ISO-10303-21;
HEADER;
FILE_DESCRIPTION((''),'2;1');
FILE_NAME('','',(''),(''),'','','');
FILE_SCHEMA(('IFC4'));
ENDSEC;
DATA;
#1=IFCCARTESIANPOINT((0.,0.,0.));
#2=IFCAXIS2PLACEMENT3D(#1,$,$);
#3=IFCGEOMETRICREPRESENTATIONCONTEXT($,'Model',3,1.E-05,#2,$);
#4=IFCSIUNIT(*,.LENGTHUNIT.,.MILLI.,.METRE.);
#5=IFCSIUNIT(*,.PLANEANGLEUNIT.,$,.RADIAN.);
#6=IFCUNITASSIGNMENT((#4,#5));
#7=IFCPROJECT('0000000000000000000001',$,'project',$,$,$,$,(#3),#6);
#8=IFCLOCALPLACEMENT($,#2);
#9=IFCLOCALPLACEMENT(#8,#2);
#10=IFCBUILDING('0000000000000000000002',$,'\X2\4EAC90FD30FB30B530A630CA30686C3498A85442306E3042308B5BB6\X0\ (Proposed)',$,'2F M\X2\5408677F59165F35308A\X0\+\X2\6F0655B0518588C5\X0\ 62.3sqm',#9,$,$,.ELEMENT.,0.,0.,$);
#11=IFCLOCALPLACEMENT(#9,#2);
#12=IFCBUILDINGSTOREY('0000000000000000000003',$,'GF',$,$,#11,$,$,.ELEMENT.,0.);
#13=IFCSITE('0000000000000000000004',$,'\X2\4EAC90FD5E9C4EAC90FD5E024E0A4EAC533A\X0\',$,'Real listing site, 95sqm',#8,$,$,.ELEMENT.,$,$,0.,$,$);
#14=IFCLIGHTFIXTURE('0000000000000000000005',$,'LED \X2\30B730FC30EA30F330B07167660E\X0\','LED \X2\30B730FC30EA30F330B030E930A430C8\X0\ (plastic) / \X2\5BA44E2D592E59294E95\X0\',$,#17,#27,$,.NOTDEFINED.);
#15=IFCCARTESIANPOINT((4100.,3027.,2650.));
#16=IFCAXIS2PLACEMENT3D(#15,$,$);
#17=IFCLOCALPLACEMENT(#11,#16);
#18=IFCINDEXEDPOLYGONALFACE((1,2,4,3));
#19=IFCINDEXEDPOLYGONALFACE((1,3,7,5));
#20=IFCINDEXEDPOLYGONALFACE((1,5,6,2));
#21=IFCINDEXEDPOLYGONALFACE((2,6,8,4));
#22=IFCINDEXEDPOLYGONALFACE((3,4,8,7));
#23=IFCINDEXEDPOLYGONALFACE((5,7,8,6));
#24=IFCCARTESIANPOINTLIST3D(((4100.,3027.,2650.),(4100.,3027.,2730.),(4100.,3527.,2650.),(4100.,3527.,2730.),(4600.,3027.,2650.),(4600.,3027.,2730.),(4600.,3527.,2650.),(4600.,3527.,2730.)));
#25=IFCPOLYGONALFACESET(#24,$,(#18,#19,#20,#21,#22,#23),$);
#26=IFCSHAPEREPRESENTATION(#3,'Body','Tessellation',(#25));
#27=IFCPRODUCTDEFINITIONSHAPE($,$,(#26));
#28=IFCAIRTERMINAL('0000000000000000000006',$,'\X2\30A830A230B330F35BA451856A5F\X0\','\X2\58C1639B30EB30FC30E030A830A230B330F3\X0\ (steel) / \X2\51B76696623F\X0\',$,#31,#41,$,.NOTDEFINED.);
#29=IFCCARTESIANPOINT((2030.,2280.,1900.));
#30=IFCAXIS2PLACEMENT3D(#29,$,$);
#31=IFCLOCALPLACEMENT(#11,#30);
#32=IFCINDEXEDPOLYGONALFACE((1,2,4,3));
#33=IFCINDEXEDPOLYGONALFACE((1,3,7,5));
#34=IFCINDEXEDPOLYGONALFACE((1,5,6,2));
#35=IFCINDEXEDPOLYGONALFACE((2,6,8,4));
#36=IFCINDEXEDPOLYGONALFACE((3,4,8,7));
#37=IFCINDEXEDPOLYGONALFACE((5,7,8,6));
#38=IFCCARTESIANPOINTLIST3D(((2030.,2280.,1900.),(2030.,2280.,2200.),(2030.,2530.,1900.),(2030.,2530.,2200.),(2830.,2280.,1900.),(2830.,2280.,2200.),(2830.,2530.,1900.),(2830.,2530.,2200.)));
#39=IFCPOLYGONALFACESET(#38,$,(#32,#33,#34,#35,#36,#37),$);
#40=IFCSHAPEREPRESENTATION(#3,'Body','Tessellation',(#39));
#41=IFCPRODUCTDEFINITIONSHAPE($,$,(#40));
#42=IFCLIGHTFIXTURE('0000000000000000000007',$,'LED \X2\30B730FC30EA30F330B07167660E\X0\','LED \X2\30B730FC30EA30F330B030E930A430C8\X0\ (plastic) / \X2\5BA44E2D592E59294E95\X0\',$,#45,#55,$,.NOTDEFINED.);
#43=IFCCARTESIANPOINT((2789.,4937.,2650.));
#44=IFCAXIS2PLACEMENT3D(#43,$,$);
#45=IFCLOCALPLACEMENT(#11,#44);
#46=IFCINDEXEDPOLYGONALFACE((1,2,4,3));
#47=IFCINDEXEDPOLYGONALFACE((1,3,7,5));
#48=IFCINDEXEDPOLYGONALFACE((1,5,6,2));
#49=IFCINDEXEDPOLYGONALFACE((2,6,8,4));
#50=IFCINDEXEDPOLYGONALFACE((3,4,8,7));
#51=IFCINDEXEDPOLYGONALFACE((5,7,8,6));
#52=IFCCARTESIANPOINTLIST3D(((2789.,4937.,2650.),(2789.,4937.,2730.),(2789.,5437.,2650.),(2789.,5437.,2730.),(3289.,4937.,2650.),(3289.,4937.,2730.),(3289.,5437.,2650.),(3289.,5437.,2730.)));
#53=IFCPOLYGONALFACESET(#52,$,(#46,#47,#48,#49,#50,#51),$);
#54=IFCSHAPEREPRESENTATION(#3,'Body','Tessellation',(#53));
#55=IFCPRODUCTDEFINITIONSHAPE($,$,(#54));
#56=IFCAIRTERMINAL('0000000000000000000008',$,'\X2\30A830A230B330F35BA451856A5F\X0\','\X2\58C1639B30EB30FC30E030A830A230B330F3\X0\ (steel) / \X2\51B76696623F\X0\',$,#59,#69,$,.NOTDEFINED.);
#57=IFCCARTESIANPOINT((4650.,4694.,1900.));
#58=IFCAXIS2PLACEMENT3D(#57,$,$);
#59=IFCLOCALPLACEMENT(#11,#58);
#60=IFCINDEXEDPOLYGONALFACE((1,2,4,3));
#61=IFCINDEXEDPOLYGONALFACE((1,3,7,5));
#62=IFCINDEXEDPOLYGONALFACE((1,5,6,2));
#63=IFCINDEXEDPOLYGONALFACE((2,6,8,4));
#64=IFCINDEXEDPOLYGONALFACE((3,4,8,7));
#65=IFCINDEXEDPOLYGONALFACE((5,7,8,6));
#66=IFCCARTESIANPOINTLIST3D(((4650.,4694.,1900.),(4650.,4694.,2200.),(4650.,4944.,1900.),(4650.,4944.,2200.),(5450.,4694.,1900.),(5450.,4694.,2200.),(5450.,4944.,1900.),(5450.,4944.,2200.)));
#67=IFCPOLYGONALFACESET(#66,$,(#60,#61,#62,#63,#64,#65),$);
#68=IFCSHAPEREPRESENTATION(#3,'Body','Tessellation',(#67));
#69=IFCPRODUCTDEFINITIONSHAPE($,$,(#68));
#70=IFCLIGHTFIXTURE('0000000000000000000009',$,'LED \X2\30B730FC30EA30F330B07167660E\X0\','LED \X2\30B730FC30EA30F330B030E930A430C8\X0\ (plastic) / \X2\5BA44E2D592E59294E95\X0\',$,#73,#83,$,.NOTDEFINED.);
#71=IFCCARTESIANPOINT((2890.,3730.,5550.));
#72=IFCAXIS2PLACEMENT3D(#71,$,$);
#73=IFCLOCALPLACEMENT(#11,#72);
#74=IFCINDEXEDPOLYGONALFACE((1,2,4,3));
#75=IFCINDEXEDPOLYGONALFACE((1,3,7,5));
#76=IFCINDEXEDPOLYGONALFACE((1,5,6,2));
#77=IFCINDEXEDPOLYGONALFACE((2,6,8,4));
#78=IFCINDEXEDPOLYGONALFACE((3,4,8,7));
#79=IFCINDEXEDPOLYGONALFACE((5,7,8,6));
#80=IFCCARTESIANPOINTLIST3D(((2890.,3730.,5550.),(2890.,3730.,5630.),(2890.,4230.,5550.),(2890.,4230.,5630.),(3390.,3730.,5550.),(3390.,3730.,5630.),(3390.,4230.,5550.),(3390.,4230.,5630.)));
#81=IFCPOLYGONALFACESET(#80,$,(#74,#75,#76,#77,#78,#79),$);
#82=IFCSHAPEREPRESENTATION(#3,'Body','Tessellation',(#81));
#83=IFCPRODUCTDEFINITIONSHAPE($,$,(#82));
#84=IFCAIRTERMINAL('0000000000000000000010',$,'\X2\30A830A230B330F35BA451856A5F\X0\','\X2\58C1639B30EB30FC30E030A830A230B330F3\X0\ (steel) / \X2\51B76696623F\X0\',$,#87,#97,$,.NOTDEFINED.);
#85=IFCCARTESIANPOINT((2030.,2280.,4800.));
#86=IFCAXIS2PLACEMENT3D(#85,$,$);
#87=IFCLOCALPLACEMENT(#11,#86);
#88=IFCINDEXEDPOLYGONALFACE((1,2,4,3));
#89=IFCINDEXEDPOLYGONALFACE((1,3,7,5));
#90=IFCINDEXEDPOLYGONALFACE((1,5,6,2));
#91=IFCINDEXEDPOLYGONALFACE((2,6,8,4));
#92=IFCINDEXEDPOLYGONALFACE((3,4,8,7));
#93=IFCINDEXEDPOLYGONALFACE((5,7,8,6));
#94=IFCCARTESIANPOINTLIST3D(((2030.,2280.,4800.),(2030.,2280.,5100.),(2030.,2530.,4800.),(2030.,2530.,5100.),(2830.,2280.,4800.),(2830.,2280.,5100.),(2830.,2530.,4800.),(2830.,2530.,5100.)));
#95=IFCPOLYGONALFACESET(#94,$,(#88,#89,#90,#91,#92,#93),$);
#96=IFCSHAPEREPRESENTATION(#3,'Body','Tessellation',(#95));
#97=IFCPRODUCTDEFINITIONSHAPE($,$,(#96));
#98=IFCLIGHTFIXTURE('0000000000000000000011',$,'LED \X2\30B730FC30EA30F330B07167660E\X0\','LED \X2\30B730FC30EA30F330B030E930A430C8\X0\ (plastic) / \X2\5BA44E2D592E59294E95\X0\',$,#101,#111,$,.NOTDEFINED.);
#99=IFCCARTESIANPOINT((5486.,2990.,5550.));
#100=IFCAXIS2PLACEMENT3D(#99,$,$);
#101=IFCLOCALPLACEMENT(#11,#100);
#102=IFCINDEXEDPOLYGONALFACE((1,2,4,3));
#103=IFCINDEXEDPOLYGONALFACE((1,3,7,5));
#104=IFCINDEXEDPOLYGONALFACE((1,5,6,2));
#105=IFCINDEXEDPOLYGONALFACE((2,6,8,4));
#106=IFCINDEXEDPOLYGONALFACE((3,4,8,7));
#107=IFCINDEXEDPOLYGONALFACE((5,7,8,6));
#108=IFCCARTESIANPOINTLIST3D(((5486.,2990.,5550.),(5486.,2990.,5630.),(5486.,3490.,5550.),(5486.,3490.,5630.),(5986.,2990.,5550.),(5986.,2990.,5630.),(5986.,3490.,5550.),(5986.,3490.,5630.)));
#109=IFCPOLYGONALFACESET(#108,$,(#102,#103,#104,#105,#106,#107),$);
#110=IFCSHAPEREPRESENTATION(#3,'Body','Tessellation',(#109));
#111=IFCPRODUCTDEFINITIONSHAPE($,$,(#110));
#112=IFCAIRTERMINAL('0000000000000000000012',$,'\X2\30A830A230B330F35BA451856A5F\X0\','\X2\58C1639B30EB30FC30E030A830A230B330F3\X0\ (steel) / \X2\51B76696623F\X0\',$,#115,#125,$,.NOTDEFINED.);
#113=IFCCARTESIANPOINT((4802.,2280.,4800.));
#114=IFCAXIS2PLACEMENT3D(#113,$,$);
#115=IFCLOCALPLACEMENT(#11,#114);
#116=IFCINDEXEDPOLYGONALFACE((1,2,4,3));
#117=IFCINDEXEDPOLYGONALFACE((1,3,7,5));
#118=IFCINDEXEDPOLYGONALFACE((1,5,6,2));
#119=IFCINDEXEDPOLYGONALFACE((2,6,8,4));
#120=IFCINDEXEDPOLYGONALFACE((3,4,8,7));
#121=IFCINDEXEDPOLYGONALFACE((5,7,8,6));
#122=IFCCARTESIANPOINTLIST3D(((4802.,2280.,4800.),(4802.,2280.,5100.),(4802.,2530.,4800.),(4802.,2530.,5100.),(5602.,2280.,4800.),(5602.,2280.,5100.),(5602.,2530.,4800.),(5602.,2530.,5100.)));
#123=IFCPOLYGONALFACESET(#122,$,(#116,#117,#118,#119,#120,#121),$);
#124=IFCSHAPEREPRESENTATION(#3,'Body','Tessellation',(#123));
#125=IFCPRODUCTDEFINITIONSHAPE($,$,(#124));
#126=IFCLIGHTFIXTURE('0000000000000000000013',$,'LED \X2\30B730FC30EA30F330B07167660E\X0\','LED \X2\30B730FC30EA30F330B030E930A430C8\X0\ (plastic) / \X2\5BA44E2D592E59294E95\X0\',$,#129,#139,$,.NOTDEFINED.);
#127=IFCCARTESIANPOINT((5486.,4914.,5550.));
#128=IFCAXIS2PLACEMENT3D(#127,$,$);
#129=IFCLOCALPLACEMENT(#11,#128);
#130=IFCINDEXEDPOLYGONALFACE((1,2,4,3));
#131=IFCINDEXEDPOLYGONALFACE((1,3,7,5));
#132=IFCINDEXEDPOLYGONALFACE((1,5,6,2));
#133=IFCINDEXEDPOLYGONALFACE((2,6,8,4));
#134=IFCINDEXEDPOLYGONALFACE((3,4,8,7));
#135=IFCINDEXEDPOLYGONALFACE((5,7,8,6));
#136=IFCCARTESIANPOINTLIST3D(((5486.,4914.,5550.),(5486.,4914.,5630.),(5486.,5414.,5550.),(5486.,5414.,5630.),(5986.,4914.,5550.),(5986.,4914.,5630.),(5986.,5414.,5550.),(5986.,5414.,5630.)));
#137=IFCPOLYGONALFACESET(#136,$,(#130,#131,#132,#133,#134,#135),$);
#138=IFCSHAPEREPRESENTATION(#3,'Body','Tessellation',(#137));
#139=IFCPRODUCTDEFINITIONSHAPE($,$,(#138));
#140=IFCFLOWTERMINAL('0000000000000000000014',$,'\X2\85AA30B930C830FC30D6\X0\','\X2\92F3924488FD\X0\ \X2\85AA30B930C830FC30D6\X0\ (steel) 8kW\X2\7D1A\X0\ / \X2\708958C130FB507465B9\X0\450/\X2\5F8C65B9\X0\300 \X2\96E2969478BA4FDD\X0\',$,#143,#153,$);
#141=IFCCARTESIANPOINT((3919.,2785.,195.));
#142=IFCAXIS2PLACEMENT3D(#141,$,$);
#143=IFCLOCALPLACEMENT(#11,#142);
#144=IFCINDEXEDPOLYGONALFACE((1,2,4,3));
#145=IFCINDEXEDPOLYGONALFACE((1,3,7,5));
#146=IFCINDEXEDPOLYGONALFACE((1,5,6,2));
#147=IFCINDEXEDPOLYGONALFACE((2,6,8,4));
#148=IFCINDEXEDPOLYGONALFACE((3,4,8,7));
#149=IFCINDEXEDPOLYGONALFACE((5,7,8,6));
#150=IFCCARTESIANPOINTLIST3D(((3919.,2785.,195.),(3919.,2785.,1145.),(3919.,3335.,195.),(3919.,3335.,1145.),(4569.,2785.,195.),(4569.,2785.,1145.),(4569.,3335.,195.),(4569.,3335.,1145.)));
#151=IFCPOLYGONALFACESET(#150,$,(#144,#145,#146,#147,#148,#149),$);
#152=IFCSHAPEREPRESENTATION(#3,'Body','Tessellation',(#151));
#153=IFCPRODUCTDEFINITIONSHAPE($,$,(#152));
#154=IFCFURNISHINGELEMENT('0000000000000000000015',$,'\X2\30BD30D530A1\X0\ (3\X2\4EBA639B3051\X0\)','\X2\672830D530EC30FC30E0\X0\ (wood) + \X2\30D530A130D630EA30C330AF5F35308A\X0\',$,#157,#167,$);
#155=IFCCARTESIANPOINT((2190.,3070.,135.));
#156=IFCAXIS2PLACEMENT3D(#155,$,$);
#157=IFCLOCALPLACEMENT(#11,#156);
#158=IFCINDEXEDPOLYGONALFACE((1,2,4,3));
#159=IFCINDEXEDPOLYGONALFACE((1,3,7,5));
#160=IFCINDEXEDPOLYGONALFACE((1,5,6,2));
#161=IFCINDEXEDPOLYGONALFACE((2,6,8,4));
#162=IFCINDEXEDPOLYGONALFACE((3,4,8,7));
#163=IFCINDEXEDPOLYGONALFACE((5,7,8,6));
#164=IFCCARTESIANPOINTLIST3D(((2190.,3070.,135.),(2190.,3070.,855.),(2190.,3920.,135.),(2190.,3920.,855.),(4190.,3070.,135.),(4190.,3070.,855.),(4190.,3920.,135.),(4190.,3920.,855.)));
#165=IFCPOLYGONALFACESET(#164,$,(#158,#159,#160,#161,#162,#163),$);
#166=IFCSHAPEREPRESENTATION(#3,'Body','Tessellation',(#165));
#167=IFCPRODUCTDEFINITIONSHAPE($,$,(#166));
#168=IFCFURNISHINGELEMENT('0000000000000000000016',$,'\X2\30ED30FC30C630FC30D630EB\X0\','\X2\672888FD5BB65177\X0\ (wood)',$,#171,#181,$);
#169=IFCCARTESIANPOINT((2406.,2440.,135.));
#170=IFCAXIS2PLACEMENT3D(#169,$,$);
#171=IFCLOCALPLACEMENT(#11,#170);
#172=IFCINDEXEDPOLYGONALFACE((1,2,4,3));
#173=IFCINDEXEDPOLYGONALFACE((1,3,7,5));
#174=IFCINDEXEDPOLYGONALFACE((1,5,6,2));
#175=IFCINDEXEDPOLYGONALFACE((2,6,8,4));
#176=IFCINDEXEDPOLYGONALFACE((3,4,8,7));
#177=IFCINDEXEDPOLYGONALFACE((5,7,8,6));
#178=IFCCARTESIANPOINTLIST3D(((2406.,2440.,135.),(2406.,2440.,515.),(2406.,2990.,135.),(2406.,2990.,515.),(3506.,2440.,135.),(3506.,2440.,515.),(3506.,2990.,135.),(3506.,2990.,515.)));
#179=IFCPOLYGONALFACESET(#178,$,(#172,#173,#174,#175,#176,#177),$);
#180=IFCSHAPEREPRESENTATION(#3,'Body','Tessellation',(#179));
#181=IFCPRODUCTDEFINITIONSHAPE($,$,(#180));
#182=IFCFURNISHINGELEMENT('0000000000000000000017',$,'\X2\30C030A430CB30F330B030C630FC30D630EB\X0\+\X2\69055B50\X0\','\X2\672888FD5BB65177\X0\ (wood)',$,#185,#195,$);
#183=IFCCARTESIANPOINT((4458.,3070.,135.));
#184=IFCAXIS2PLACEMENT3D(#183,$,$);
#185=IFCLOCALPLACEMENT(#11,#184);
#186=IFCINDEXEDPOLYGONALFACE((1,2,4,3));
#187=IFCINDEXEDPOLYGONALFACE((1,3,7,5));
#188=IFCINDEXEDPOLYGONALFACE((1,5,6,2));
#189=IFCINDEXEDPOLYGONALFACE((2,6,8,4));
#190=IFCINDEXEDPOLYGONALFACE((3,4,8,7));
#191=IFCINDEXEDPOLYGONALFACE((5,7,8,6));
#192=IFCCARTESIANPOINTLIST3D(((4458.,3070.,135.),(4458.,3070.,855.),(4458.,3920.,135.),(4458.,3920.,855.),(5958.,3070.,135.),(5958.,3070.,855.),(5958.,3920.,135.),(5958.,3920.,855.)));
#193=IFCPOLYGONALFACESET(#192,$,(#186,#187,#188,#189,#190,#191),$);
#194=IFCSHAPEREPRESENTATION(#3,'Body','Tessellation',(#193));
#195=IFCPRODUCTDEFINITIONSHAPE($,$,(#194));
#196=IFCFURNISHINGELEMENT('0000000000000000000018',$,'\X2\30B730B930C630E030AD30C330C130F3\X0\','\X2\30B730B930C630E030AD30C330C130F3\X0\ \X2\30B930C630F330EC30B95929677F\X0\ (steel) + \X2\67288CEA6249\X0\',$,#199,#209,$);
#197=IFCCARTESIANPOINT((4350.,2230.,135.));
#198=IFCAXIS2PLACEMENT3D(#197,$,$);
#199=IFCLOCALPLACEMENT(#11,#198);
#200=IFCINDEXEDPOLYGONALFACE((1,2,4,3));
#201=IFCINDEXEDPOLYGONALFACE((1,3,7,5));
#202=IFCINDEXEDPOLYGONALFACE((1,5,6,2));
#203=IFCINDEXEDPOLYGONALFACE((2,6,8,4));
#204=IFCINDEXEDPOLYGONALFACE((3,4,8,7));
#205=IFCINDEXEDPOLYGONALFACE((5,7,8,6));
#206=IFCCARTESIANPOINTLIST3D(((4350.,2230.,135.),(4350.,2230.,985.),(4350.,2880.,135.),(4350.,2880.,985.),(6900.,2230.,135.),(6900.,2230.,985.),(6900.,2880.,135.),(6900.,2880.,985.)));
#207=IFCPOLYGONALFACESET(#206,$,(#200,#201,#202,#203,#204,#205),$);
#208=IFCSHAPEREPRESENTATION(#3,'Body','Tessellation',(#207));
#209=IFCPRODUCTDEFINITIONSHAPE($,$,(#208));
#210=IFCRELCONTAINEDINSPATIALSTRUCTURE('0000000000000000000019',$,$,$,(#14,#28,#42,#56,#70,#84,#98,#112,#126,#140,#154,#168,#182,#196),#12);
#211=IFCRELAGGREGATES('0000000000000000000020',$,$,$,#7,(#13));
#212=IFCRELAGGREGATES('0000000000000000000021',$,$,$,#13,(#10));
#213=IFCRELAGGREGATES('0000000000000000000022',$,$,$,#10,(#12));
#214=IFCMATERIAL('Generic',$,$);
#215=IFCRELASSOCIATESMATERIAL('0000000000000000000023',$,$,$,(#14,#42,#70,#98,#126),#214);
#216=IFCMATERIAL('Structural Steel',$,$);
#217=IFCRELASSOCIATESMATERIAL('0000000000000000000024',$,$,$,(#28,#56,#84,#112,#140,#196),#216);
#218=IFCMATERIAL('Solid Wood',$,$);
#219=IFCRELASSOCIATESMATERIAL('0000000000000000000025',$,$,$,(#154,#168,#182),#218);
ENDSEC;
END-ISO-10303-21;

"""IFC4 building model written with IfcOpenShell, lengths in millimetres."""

from ifc_helpers import new_model, si_unit, frame, frame_2d, origin, place, context, project, spatial, rectangle, extrude, material, element, save


model = new_model("IFC4")

# Units and contexts
model_context = context("Model", 3, precision=1e-05, world=origin())
ifc_project = project(units=[si_unit("LENGTHUNIT", "METRE", prefix="MILLI"), si_unit("PLANEANGLEUNIT", "RADIAN")], contexts=[model_context])

# Site, building, storey
site_placement = place(None, origin())
site = spatial("IfcSite", under=ifc_project, at=site_placement, Name="京都府京都市上京区", ObjectType="Real listing site, 95sqm", CompositionType="ELEMENT", RefElevation=0.0)
building_placement = place(site_placement, origin())
building = spatial("IfcBuilding", under=site, at=building_placement, Name="京都・サウナと水風呂のある家 (Proposed)", ObjectType="2F M合板外張り+漆喰内装 62.3sqm", CompositionType="ELEMENT", ElevationOfRefHeight=0.0, ElevationOfTerrain=0.0)
storey_placement = place(building_placement, origin())
storey = spatial("IfcBuildingStorey", under=building, at=storey_placement, Name="GF", CompositionType="ELEMENT", Elevation=0.0)

# Shared definitions
ifc_material_1 = material(Name="Solid Wood")

# Shared definitions
ifc_material_2 = material(Name="Structural Steel")

# Shared definitions
ifc_material_3 = material(Name="Generic")

# Light fixture
light_fixture_1_placement = place(storey_placement, frame((4100.0, 3027.0, 2650.0)))
element("IfcLightFixture", 1, at=light_fixture_1_placement, inside=storey, material=ifc_material_3, Name="LED シーリング照明", Description="LED シーリングライト (plastic) / 室中央天井", PredefinedType="NOTDEFINED", context=model_context, shape_type="SweptSolid", body=[
    extrude(rectangle(XDim=500.0, YDim=500.0, at=frame_2d((250.0, 250.0))), frame((4100.0, 3027.0, 2650.0)), (0.0, 0.0, 1.0), 80.0),
])

# Air terminal
air_terminal_1_placement = place(storey_placement, frame((2030.0, 2280.0, 1900.0)))
element("IfcAirTerminal", 2, at=air_terminal_1_placement, inside=storey, material=ifc_material_2, Name="エアコン室内機", Description="壁掛ルームエアコン (steel) / 冷暖房", PredefinedType="NOTDEFINED", context=model_context, shape_type="SweptSolid", body=[
    extrude(rectangle(XDim=800.0, YDim=250.0, at=frame_2d((400.0, 125.0))), frame((2030.0, 2280.0, 1900.0)), (0.0, 0.0, 1.0), 300.0),
])

# Light fixture
light_fixture_2_placement = place(storey_placement, frame((2789.0, 4937.0, 2650.0)))
element("IfcLightFixture", 3, at=light_fixture_2_placement, inside=storey, material=ifc_material_3, Name="LED シーリング照明", Description="LED シーリングライト (plastic) / 室中央天井", PredefinedType="NOTDEFINED", context=model_context, shape_type="SweptSolid", body=[
    extrude(rectangle(XDim=500.0, YDim=500.0, at=frame_2d((250.0, 250.0))), frame((2789.0, 4937.0, 2650.0)), (0.0, 0.0, 1.0), 80.0),
])

# Air terminal
air_terminal_2_placement = place(storey_placement, frame((4650.0, 4694.0, 1900.0)))
element("IfcAirTerminal", 4, at=air_terminal_2_placement, inside=storey, material=ifc_material_2, Name="エアコン室内機", Description="壁掛ルームエアコン (steel) / 冷暖房", PredefinedType="NOTDEFINED", context=model_context, shape_type="SweptSolid", body=[
    extrude(rectangle(XDim=800.0, YDim=250.0, at=frame_2d((400.0, 125.0))), frame((4650.0, 4694.0, 1900.0)), (0.0, 0.0, 1.0), 300.0),
])

# Light fixture
light_fixture_3_placement = place(storey_placement, frame((2890.0, 3730.0, 5550.0)))
element("IfcLightFixture", 5, at=light_fixture_3_placement, inside=storey, material=ifc_material_3, Name="LED シーリング照明", Description="LED シーリングライト (plastic) / 室中央天井", PredefinedType="NOTDEFINED", context=model_context, shape_type="SweptSolid", body=[
    extrude(rectangle(XDim=500.0, YDim=500.0, at=frame_2d((250.0, 250.0))), frame((2890.0, 3730.0, 5550.0)), (0.0, 0.0, 1.0), 80.0),
])

# Air terminal
air_terminal_3_placement = place(storey_placement, frame((2030.0, 2280.0, 4800.0)))
element("IfcAirTerminal", 6, at=air_terminal_3_placement, inside=storey, material=ifc_material_2, Name="エアコン室内機", Description="壁掛ルームエアコン (steel) / 冷暖房", PredefinedType="NOTDEFINED", context=model_context, shape_type="SweptSolid", body=[
    extrude(rectangle(XDim=800.0, YDim=250.0, at=frame_2d((400.0, 125.0))), frame((2030.0, 2280.0, 4800.0)), (0.0, 0.0, 1.0), 300.0),
])

# Light fixture
light_fixture_4_placement = place(storey_placement, frame((5486.0, 2990.0, 5550.0)))
element("IfcLightFixture", 7, at=light_fixture_4_placement, inside=storey, material=ifc_material_3, Name="LED シーリング照明", Description="LED シーリングライト (plastic) / 室中央天井", PredefinedType="NOTDEFINED", context=model_context, shape_type="SweptSolid", body=[
    extrude(rectangle(XDim=500.0, YDim=500.0, at=frame_2d((250.0, 250.0))), frame((5486.0, 2990.0, 5550.0)), (0.0, 0.0, 1.0), 80.0),
])

# Air terminal
air_terminal_4_placement = place(storey_placement, frame((4802.0, 2280.0, 4800.0)))
element("IfcAirTerminal", 8, at=air_terminal_4_placement, inside=storey, material=ifc_material_2, Name="エアコン室内機", Description="壁掛ルームエアコン (steel) / 冷暖房", PredefinedType="NOTDEFINED", context=model_context, shape_type="SweptSolid", body=[
    extrude(rectangle(XDim=800.0, YDim=250.0, at=frame_2d((400.0, 125.0))), frame((4802.0, 2280.0, 4800.0)), (0.0, 0.0, 1.0), 300.0),
])

# Light fixture
light_fixture_5_placement = place(storey_placement, frame((5486.0, 4914.0, 5550.0)))
element("IfcLightFixture", 9, at=light_fixture_5_placement, inside=storey, material=ifc_material_3, Name="LED シーリング照明", Description="LED シーリングライト (plastic) / 室中央天井", PredefinedType="NOTDEFINED", context=model_context, shape_type="SweptSolid", body=[
    extrude(rectangle(XDim=500.0, YDim=500.0, at=frame_2d((250.0, 250.0))), frame((5486.0, 4914.0, 5550.0)), (0.0, 0.0, 1.0), 80.0),
])

# Flow terminal
flow_terminal_1_placement = place(storey_placement, frame((3919.0, 2785.0, 195.0)))
element("IfcFlowTerminal", 10, at=flow_terminal_1_placement, inside=storey, material=ifc_material_2, Name="薪ストーブ", Description="鋳鉄製 薪ストーブ (steel) 8kW級 / 炉壁・側方450/後方300 離隔確保", context=model_context, shape_type="SweptSolid", body=[
    extrude(rectangle(XDim=650.0, YDim=550.0, at=frame_2d((325.0, 275.0))), frame((3919.0, 2785.0, 195.0)), (0.0, 0.0, 1.0), 950.0),
])

# Furnishing elements
furnishing_1_placement = place(storey_placement, frame((2190.0, 3070.0, 135.0)))
element("IfcFurnishingElement", 11, at=furnishing_1_placement, inside=storey, material=ifc_material_1, Name="ソファ (3人掛け)", Description="木フレーム (wood) + ファブリック張り", context=model_context, shape_type="SweptSolid", body=[
    extrude(rectangle(XDim=2000.0, YDim=850.0, at=frame_2d((1000.0, 425.0))), frame((2190.0, 3070.0, 135.0)), (0.0, 0.0, 1.0), 720.0),
])
furnishing_2_placement = place(storey_placement, frame((2406.0, 2440.0, 135.0)))
element("IfcFurnishingElement", 12, at=furnishing_2_placement, inside=storey, material=ifc_material_1, Name="ローテーブル", Description="木製家具 (wood)", context=model_context, shape_type="SweptSolid", body=[
    extrude(rectangle(XDim=1100.0, YDim=550.0, at=frame_2d((550.0, 275.0))), frame((2406.0, 2440.0, 135.0)), (0.0, 0.0, 1.0), 380.0),
])
furnishing_3_placement = place(storey_placement, frame((4458.0, 3070.0, 135.0)))
element("IfcFurnishingElement", 13, at=furnishing_3_placement, inside=storey, material=ifc_material_1, Name="ダイニングテーブル+椅子", Description="木製家具 (wood)", context=model_context, shape_type="SweptSolid", body=[
    extrude(rectangle(XDim=1500.0, YDim=850.0, at=frame_2d((750.0, 425.0))), frame((4458.0, 3070.0, 135.0)), (0.0, 0.0, 1.0), 720.0),
])
furnishing_4_placement = place(storey_placement, frame((4350.0, 2230.0, 135.0)))
element("IfcFurnishingElement", 14, at=furnishing_4_placement, inside=storey, material=ifc_material_2, Name="システムキッチン", Description="システムキッチン ステンレス天板 (steel) + 木質扉", context=model_context, shape_type="SweptSolid", body=[
    extrude(rectangle(XDim=2550.0, YDim=650.0, at=frame_2d((1275.0, 325.0))), frame((4350.0, 2230.0, 135.0)), (0.0, 0.0, 1.0), 850.0),
])

save(model, "model.ifc")
